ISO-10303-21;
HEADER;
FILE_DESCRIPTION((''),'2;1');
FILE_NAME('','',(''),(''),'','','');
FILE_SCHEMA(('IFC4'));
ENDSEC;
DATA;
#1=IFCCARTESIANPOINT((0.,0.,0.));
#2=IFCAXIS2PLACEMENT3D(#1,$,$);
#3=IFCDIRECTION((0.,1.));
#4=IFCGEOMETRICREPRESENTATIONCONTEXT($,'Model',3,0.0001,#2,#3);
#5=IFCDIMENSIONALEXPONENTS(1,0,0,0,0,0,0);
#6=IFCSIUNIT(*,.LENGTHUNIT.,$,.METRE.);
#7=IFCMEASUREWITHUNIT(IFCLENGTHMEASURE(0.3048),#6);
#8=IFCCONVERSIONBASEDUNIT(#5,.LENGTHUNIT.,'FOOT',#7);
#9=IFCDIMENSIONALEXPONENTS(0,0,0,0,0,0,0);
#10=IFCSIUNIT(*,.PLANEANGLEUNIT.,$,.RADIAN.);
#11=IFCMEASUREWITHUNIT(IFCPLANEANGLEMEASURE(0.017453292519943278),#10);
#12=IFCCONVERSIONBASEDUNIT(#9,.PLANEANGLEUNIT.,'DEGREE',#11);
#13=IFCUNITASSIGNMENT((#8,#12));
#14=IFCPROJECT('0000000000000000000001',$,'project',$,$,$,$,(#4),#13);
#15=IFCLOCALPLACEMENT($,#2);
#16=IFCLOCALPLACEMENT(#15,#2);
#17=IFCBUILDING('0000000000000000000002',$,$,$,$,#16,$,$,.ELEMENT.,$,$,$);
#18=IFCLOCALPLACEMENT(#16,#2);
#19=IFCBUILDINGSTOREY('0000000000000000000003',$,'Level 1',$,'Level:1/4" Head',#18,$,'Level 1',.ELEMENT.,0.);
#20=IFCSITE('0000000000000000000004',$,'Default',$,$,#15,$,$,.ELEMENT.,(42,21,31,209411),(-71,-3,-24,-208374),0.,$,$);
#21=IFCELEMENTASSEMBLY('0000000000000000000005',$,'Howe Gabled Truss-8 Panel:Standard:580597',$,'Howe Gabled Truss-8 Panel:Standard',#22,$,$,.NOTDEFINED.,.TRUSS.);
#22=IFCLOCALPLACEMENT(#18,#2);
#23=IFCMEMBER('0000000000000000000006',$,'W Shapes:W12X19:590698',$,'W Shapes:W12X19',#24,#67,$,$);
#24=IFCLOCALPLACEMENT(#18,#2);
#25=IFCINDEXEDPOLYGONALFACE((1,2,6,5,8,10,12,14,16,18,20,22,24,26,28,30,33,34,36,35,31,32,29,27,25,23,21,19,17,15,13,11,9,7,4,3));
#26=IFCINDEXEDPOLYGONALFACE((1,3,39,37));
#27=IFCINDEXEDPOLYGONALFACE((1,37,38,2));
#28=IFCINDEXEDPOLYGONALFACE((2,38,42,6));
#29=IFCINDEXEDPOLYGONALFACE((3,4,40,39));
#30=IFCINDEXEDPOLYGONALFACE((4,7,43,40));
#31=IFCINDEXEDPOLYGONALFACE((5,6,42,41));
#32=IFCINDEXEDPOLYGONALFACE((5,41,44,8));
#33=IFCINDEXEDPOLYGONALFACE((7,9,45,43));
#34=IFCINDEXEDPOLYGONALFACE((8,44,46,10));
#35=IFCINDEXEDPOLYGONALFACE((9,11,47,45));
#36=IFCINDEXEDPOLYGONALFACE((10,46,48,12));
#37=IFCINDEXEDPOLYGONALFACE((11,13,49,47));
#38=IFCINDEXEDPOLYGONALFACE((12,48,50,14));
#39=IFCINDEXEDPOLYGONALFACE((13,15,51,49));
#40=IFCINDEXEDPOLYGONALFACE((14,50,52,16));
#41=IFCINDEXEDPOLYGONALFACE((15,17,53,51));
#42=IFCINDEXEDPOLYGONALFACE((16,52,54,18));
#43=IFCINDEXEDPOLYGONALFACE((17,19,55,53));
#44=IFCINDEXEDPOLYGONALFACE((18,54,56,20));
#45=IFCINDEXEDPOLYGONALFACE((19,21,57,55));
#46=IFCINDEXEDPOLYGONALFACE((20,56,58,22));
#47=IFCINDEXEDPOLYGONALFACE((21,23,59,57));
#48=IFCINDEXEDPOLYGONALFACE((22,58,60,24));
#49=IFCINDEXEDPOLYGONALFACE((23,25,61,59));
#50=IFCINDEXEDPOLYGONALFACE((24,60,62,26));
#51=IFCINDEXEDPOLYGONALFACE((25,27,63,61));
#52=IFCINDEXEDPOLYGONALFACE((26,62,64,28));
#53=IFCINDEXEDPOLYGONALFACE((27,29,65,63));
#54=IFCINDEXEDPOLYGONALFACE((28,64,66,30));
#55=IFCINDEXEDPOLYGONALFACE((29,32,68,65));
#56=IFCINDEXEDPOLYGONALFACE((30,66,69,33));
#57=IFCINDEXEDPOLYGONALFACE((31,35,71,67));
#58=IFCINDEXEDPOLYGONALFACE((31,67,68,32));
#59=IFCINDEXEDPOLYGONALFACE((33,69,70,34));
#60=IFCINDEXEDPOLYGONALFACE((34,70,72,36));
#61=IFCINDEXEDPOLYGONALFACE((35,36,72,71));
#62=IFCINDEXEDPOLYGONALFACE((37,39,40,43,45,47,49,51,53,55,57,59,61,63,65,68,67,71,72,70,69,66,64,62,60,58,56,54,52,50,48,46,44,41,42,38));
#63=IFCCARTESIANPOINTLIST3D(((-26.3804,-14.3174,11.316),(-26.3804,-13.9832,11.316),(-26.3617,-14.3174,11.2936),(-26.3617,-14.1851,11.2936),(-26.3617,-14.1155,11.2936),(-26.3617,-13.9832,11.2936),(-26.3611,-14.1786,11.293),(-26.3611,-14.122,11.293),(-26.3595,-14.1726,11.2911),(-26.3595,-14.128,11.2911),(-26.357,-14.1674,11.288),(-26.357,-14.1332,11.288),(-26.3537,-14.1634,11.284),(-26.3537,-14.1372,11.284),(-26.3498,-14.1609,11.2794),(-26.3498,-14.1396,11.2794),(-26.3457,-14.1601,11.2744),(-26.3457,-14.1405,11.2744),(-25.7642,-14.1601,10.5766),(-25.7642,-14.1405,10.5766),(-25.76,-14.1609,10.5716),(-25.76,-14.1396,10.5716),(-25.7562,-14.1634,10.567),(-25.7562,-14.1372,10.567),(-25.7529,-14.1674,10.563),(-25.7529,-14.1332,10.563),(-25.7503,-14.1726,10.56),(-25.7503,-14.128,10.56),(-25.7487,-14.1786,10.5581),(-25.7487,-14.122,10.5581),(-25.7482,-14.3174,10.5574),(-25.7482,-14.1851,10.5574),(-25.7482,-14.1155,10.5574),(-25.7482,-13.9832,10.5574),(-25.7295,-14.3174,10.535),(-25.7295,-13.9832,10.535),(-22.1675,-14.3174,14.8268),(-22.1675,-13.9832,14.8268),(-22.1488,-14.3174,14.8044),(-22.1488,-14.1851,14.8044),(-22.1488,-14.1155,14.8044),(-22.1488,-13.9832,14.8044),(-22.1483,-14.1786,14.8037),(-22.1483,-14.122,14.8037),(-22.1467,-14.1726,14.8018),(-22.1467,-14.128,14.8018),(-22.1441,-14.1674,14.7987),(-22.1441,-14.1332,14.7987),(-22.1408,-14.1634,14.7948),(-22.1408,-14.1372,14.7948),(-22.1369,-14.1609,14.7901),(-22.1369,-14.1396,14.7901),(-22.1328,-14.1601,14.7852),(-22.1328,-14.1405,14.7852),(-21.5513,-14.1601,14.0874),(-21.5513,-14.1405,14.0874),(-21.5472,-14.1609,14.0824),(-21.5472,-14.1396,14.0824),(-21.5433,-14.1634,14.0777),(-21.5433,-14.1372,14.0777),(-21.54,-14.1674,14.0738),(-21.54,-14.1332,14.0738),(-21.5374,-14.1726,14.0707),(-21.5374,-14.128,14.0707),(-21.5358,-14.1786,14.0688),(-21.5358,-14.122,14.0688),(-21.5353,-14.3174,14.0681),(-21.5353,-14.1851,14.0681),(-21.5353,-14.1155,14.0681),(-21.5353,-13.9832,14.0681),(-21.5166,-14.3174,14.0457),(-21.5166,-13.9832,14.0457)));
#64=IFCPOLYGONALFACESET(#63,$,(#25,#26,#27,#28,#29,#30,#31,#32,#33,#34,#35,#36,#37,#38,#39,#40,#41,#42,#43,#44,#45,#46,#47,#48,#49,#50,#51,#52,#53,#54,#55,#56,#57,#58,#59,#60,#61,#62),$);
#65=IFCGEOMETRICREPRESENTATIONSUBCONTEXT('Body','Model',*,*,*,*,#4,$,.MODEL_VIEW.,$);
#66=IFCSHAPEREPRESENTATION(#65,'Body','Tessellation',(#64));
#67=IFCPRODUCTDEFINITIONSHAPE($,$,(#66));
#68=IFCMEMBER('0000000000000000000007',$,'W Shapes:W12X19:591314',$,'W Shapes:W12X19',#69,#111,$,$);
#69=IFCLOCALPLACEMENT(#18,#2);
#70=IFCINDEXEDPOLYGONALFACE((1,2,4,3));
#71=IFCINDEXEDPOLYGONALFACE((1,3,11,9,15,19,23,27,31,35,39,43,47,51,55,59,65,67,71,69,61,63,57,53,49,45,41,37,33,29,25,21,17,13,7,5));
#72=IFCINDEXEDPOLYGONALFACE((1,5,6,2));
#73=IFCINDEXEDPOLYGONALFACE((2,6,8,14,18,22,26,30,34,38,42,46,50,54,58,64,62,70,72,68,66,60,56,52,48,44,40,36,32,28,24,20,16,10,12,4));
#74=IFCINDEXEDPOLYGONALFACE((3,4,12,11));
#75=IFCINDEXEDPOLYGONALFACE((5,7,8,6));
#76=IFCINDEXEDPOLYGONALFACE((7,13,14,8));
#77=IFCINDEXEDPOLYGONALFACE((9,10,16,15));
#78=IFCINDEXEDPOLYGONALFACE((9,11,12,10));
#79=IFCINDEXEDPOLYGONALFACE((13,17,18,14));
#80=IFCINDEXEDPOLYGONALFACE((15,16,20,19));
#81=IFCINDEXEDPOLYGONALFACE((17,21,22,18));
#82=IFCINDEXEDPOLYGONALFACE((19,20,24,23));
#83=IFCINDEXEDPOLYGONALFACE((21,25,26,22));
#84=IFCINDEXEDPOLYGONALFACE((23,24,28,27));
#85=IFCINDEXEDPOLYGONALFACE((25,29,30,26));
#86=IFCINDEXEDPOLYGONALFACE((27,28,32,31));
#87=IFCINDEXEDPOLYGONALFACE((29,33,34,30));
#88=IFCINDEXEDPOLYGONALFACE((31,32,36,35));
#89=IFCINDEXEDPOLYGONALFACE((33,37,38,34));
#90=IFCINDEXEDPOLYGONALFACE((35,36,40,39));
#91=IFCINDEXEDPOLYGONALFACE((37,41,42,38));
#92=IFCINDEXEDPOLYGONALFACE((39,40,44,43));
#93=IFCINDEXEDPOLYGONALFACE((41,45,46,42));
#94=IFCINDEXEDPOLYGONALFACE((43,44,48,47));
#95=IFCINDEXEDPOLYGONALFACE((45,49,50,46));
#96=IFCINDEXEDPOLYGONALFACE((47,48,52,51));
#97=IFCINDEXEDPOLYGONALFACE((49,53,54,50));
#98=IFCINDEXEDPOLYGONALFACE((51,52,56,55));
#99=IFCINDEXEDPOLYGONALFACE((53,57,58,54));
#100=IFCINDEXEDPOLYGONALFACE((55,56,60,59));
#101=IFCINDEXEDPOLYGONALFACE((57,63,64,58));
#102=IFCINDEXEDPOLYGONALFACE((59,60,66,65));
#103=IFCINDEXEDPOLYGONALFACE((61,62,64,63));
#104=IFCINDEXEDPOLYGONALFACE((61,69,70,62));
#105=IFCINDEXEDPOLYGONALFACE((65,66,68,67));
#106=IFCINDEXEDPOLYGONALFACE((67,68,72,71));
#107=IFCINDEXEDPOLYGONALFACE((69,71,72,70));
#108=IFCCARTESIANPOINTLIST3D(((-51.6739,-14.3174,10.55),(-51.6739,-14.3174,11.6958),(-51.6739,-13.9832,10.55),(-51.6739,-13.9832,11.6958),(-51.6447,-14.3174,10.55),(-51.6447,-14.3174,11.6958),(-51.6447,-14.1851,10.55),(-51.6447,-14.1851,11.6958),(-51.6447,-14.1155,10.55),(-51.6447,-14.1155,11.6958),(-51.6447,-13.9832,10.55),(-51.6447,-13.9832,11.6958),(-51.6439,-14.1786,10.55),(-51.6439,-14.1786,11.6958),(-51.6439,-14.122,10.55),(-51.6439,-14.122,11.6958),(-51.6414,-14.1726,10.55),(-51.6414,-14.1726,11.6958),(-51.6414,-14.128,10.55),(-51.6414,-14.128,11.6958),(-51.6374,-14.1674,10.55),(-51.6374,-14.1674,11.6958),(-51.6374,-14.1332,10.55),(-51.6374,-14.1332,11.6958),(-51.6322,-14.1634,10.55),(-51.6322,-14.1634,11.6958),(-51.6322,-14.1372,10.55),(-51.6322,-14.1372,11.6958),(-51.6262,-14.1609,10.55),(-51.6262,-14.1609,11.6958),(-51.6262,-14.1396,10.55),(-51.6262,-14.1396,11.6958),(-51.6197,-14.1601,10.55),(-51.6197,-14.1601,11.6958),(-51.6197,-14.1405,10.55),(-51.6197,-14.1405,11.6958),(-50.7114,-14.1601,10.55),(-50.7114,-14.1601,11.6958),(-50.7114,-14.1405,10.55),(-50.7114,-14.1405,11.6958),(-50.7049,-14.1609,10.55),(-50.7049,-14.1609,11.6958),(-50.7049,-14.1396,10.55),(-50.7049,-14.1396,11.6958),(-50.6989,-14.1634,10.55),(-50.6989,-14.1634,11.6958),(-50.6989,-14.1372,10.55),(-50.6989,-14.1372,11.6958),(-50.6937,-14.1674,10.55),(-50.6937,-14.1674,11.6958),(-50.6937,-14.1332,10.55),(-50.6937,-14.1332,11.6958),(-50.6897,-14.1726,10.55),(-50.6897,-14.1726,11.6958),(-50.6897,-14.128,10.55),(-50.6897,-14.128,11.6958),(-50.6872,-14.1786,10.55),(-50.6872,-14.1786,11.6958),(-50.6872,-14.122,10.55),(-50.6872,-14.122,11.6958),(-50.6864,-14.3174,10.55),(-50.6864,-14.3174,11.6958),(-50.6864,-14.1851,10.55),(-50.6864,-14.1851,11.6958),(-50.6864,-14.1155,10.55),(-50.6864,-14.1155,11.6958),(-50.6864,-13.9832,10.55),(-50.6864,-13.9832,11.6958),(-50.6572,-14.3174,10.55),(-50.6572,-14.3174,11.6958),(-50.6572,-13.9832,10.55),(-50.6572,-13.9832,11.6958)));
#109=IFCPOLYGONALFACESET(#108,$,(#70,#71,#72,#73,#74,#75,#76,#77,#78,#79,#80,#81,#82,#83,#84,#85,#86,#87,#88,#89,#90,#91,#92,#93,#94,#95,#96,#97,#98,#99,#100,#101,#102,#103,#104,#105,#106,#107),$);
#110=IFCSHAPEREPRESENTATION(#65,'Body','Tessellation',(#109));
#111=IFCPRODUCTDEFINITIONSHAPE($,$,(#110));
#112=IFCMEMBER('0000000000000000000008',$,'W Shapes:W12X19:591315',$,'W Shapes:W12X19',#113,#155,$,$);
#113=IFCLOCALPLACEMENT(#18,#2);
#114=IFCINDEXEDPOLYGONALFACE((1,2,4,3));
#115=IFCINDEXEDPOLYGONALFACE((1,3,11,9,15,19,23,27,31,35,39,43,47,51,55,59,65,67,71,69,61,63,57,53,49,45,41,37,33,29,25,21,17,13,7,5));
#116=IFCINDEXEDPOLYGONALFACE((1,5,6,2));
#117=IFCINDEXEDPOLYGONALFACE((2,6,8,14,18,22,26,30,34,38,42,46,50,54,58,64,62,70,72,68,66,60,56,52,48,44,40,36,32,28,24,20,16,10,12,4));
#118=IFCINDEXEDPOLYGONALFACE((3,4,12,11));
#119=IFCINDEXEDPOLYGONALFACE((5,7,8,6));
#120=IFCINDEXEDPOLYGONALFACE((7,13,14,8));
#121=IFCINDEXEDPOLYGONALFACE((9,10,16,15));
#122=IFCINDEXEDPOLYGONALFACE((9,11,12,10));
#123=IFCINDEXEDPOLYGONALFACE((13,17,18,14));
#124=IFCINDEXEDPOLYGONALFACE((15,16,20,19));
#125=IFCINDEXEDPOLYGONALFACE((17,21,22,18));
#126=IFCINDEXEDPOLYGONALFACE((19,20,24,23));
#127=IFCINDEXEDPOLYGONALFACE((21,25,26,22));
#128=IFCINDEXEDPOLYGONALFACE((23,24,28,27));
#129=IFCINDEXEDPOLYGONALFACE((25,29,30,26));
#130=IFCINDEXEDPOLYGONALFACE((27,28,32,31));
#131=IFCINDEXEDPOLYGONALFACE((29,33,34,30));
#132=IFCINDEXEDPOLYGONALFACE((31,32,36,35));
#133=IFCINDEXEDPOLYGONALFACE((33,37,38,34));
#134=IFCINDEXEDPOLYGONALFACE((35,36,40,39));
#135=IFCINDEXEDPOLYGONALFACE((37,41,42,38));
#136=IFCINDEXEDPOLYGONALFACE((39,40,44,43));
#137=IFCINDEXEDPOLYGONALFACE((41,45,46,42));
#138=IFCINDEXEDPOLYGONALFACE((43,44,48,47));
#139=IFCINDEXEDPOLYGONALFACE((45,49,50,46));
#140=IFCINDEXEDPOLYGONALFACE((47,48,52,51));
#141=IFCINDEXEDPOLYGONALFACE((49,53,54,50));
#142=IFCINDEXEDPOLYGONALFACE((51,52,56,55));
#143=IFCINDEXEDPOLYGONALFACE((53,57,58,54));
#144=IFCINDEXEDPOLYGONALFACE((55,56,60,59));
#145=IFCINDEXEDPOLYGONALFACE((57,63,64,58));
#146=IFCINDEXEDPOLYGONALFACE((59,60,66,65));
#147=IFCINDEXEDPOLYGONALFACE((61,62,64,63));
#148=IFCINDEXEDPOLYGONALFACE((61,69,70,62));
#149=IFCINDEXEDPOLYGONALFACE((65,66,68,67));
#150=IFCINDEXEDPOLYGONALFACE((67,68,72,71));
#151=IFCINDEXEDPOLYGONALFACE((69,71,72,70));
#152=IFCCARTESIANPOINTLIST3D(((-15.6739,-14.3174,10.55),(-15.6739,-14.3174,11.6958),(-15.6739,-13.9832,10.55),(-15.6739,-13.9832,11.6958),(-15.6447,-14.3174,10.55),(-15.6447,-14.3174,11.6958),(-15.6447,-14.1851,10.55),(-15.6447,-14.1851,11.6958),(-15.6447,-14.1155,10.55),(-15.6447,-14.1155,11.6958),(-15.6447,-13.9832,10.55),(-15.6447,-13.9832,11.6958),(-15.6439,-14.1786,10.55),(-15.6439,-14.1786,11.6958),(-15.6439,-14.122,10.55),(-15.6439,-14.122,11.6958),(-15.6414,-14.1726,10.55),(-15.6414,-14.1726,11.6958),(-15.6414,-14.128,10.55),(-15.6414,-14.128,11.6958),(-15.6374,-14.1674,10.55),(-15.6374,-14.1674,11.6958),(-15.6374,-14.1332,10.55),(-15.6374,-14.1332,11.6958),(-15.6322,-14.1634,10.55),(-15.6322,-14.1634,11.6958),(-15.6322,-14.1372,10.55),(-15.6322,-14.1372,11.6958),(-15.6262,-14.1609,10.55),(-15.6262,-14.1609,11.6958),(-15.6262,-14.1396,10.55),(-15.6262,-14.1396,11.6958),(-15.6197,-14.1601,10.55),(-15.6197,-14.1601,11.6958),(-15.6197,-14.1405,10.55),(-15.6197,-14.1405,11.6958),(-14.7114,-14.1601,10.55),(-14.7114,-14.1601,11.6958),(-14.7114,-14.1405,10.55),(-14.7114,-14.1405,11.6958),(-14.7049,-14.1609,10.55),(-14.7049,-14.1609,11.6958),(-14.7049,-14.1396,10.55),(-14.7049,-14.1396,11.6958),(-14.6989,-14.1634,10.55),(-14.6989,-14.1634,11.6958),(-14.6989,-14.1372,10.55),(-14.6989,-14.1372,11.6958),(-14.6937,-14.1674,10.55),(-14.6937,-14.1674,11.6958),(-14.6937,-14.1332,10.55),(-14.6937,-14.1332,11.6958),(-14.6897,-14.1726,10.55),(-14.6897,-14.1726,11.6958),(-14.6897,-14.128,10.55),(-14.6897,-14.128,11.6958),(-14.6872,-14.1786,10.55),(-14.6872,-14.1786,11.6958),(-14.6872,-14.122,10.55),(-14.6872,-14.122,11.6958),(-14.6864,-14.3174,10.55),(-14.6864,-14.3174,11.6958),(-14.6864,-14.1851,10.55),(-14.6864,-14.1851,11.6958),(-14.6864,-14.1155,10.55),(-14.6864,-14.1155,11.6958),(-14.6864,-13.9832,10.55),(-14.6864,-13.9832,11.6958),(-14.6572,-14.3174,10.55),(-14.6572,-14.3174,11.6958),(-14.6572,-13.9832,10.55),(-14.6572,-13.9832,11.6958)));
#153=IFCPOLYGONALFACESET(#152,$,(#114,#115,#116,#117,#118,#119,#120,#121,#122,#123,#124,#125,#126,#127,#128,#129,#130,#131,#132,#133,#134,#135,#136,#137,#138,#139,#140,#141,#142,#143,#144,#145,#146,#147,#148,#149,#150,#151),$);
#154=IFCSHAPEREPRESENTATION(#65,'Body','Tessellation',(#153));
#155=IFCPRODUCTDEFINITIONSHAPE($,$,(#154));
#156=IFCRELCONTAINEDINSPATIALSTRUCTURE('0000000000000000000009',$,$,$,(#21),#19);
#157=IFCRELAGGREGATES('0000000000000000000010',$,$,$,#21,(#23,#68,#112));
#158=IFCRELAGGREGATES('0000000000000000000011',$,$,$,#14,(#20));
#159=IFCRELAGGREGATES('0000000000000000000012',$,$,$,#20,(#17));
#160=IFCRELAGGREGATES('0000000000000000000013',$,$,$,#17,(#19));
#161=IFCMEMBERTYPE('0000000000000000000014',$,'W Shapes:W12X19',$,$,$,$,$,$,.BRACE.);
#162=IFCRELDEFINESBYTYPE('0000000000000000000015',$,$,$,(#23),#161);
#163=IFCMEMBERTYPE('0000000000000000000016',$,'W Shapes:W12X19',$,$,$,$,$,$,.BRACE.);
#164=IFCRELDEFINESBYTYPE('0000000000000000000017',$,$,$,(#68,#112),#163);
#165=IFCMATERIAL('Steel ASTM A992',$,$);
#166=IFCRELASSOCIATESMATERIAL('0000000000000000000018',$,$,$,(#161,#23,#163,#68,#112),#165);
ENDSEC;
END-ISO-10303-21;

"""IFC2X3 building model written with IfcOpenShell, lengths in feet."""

from ifc_helpers import new_model, entity, si_unit, converted_unit, direction, frame, frame_2d, origin, place, context, subcontext, project, spatial, polyline, circle_curve, parameter, trimmed, segment, composite_curve, outline, extrude, source, transform, mapped, material, type_object, type_shapes, element, aggregate, save


model = new_model("IFC2X3")

# Units and contexts
model_context = context("Model", 3, precision=0.0001, world=origin(), true_north=direction((0.0, 1.0)))
body_context = subcontext(model_context, "Body", "Model", "MODEL_VIEW")
ifc_project = project(units=[converted_unit("LENGTHUNIT", "FOOT", entity("IfcLengthMeasure", 0.3048), si_unit("LENGTHUNIT", "METRE"), dimensions=[1, 0, 0, 0, 0, 0, 0]), converted_unit("PLANEANGLEUNIT", "DEGREE", entity("IfcPlaneAngleMeasure", 0.017453292519943278), si_unit("PLANEANGLEUNIT", "RADIAN"), dimensions=[0, 0, 0, 0, 0, 0, 0])], contexts=[model_context])

# Site, building, storey
site_placement = place(None, origin())
site = spatial("IfcSite", under=ifc_project, at=site_placement, Name="Default", CompositionType="ELEMENT", RefLatitude=(42, 21, 31, 209411), RefLongitude=(-71, -3, -24, -208374), RefElevation=0.0)
building_placement = place(site_placement, origin())
building = spatial("IfcBuilding", under=site, at=building_placement, CompositionType="ELEMENT")
storey_placement = place(building_placement, origin())
storey = spatial("IfcBuildingStorey", under=building, at=storey_placement, Name="Level 1", ObjectType="Level:1/4\" Head", LongName="Level 1", CompositionType="ELEMENT", Elevation=0.0)

# Element assembly, members
assembly_placement = place(storey_placement, origin())
assembly = element("IfcElementAssembly", 1, at=assembly_placement, inside=storey, Name="Howe Gabled Truss-8 Panel:Standard:580597", ObjectType="Howe Gabled Truss-8 Panel:Standard", AssemblyPlace="NOTDEFINED", PredefinedType="TRUSS")
ifc_material = material(Name="Steel ASTM A992")
member_type_1 = type_object("IfcMemberType", Name="W Shapes:W12X19", PredefinedType="BRACE", material=ifc_material)
shared_shape_1 = source(origin(), body_context, "Body", "SweptSolid", [
    extrude(outline(composite_curve([segment(polyline([(-0.1671, -0.4792), (-0.1671, -0.5083)]), True, "CONTINUOUS"), segment(polyline([(-0.1671, -0.5083), (0.1671, -0.5083)]), True, "CONTINUOUS"), segment(polyline([(0.1671, -0.5083), (0.1671, -0.4792)]), True, "CONTINUOUS"), segment(polyline([(0.1671, -0.4792), (0.0348, -0.4792)]), True, "CONTINUOUS"), segment(trimmed(circle_curve(frame_2d((0.0348, -0.4542), x_axis=(0.0, -1.0)), 0.025), [parameter(270.0)], [parameter(360.0)], True, "PARAMETER"), False, "CONTINUOUS"), segment(polyline([(0.0098, -0.4542), (0.0098, 0.4542)]), True, "CONTINUOUS"), segment(trimmed(circle_curve(frame_2d((0.0348, 0.4542), x_axis=(-1.0, 0.0)), 0.025), [parameter(270.0)], [parameter(360.0)], True, "PARAMETER"), False, "CONTINUOUS"), segment(polyline([(0.0348, 0.4792), (0.1671, 0.4792)]), True, "CONTINUOUS"), segment(polyline([(0.1671, 0.4792), (0.1671, 0.5083)]), True, "CONTINUOUS"), segment(polyline([(0.1671, 0.5083), (-0.1671, 0.5083)]), True, "CONTINUOUS"), segment(polyline([(-0.1671, 0.5083), (-0.1671, 0.4792)]), True, "CONTINUOUS"), segment(polyline([(-0.1671, 0.4792), (-0.0348, 0.4792)]), True, "CONTINUOUS"), segment(trimmed(circle_curve(frame_2d((-0.0348, 0.4542), x_axis=(0.0, 1.0)), 0.025), [parameter(270.0)], [parameter(0.0)], True, "PARAMETER"), False, "CONTINUOUS"), segment(polyline([(-0.0098, 0.4542), (-0.0098, -0.4542)]), True, "CONTINUOUS"), segment(trimmed(circle_curve(frame_2d((-0.0348, -0.4542), x_axis=(1.0, 0.0)), 0.025), [parameter(270.0)], [parameter(0.0)], True, "PARAMETER"), False, "CONTINUOUS"), segment(polyline([(-0.0348, -0.4792), (-0.1671, -0.4792)]), True, "CONTINUOUS")], self_intersect=False)), frame((-2.4594, 0.0, 0.0), z_axis=(-1.0, 0.0, 0.0), x_axis=(0.0, -1.0, 0.0)), (0.0, 0.0, -1.0), 5.4839),
])
type_shapes(member_type_1, [shared_shape_1])
member_1_placement = place(assembly_placement, frame((-24.1655, -14.1503, 12.5), z_axis=(0.640184, 0.0, -0.768221), x_axis=(0.768221, 0.0, 0.640184)))
member_1 = element("IfcMember", 2, at=member_1_placement, type_object=member_type_1, material=ifc_material, Name="W Shapes:W12X19:590698", ObjectType="W Shapes:W12X19", context=body_context, shape_type="MappedRepresentation", body=[
    mapped(shared_shape_1, transform((0.0, 0.0, 0.0), scale=1.0)),
])
member_type_2 = type_object("IfcMemberType", Name="W Shapes:W12X19", PredefinedType="BRACE", material=ifc_material)
shared_shape_2 = source(origin(), body_context, "Body", "SweptSolid", [
    extrude(outline(composite_curve([segment(polyline([(-0.1671, -0.4792), (-0.1671, -0.5083)]), True, "CONTINUOUS"), segment(polyline([(-0.1671, -0.5083), (0.1671, -0.5083)]), True, "CONTINUOUS"), segment(polyline([(0.1671, -0.5083), (0.1671, -0.4792)]), True, "CONTINUOUS"), segment(polyline([(0.1671, -0.4792), (0.0348, -0.4792)]), True, "CONTINUOUS"), segment(trimmed(circle_curve(frame_2d((0.0348, -0.4542), x_axis=(0.0, -1.0)), 0.025), [parameter(270.0)], [parameter(360.0)], True, "PARAMETER"), False, "CONTINUOUS"), segment(polyline([(0.0098, -0.4542), (0.0098, 0.4542)]), True, "CONTINUOUS"), segment(trimmed(circle_curve(frame_2d((0.0348, 0.4542), x_axis=(-1.0, 0.0)), 0.025), [parameter(270.0)], [parameter(360.0)], True, "PARAMETER"), False, "CONTINUOUS"), segment(polyline([(0.0348, 0.4792), (0.1671, 0.4792)]), True, "CONTINUOUS"), segment(polyline([(0.1671, 0.4792), (0.1671, 0.5083)]), True, "CONTINUOUS"), segment(polyline([(0.1671, 0.5083), (-0.1671, 0.5083)]), True, "CONTINUOUS"), segment(polyline([(-0.1671, 0.5083), (-0.1671, 0.4792)]), True, "CONTINUOUS"), segment(polyline([(-0.1671, 0.4792), (-0.0348, 0.4792)]), True, "CONTINUOUS"), segment(trimmed(circle_curve(frame_2d((-0.0348, 0.4542), x_axis=(0.0, 1.0)), 0.025), [parameter(270.0)], [parameter(0.0)], True, "PARAMETER"), False, "CONTINUOUS"), segment(polyline([(-0.0098, 0.4542), (-0.0098, -0.4542)]), True, "CONTINUOUS"), segment(trimmed(circle_curve(frame_2d((-0.0348, -0.4542), x_axis=(1.0, 0.0)), 0.025), [parameter(270.0)], [parameter(0.0)], True, "PARAMETER"), False, "CONTINUOUS"), segment(polyline([(-0.0348, -0.4792), (-0.1671, -0.4792)]), True, "CONTINUOUS")], self_intersect=False)), frame((-0.7, 0.0, 0.0), z_axis=(-1.0, 0.0, 0.0), x_axis=(0.0, -1.0, 0.0)), (0.0, 0.0, -1.0), 1.1458),
])
type_shapes(member_type_2, [shared_shape_2])
member_2_placement = place(assembly_placement, frame((-51.1655, -14.1503, 11.25), z_axis=(1.0, 0.0, 0.0), x_axis=(0.0, 0.0, 1.0)))
member_2 = element("IfcMember", 3, at=member_2_placement, type_object=member_type_2, material=ifc_material, Name="W Shapes:W12X19:591314", ObjectType="W Shapes:W12X19", context=body_context, shape_type="MappedRepresentation", body=[
    mapped(shared_shape_2, transform((0.0, 0.0, 0.0), scale=1.0)),
])
member_3_placement = place(assembly_placement, frame((-15.1655, -14.1503, 11.25), z_axis=(1.0, 0.0, 0.0), x_axis=(0.0, 0.0, 1.0)))
member_3 = element("IfcMember", 4, at=member_3_placement, type_object=member_type_2, material=ifc_material, Name="W Shapes:W12X19:591315", ObjectType="W Shapes:W12X19", context=body_context, shape_type="MappedRepresentation", body=[
    mapped(shared_shape_2, transform((0.0, 0.0, 0.0), scale=1.0)),
])
aggregate(assembly, [member_1, member_2, member_3])

save(model, "model.ifc")
